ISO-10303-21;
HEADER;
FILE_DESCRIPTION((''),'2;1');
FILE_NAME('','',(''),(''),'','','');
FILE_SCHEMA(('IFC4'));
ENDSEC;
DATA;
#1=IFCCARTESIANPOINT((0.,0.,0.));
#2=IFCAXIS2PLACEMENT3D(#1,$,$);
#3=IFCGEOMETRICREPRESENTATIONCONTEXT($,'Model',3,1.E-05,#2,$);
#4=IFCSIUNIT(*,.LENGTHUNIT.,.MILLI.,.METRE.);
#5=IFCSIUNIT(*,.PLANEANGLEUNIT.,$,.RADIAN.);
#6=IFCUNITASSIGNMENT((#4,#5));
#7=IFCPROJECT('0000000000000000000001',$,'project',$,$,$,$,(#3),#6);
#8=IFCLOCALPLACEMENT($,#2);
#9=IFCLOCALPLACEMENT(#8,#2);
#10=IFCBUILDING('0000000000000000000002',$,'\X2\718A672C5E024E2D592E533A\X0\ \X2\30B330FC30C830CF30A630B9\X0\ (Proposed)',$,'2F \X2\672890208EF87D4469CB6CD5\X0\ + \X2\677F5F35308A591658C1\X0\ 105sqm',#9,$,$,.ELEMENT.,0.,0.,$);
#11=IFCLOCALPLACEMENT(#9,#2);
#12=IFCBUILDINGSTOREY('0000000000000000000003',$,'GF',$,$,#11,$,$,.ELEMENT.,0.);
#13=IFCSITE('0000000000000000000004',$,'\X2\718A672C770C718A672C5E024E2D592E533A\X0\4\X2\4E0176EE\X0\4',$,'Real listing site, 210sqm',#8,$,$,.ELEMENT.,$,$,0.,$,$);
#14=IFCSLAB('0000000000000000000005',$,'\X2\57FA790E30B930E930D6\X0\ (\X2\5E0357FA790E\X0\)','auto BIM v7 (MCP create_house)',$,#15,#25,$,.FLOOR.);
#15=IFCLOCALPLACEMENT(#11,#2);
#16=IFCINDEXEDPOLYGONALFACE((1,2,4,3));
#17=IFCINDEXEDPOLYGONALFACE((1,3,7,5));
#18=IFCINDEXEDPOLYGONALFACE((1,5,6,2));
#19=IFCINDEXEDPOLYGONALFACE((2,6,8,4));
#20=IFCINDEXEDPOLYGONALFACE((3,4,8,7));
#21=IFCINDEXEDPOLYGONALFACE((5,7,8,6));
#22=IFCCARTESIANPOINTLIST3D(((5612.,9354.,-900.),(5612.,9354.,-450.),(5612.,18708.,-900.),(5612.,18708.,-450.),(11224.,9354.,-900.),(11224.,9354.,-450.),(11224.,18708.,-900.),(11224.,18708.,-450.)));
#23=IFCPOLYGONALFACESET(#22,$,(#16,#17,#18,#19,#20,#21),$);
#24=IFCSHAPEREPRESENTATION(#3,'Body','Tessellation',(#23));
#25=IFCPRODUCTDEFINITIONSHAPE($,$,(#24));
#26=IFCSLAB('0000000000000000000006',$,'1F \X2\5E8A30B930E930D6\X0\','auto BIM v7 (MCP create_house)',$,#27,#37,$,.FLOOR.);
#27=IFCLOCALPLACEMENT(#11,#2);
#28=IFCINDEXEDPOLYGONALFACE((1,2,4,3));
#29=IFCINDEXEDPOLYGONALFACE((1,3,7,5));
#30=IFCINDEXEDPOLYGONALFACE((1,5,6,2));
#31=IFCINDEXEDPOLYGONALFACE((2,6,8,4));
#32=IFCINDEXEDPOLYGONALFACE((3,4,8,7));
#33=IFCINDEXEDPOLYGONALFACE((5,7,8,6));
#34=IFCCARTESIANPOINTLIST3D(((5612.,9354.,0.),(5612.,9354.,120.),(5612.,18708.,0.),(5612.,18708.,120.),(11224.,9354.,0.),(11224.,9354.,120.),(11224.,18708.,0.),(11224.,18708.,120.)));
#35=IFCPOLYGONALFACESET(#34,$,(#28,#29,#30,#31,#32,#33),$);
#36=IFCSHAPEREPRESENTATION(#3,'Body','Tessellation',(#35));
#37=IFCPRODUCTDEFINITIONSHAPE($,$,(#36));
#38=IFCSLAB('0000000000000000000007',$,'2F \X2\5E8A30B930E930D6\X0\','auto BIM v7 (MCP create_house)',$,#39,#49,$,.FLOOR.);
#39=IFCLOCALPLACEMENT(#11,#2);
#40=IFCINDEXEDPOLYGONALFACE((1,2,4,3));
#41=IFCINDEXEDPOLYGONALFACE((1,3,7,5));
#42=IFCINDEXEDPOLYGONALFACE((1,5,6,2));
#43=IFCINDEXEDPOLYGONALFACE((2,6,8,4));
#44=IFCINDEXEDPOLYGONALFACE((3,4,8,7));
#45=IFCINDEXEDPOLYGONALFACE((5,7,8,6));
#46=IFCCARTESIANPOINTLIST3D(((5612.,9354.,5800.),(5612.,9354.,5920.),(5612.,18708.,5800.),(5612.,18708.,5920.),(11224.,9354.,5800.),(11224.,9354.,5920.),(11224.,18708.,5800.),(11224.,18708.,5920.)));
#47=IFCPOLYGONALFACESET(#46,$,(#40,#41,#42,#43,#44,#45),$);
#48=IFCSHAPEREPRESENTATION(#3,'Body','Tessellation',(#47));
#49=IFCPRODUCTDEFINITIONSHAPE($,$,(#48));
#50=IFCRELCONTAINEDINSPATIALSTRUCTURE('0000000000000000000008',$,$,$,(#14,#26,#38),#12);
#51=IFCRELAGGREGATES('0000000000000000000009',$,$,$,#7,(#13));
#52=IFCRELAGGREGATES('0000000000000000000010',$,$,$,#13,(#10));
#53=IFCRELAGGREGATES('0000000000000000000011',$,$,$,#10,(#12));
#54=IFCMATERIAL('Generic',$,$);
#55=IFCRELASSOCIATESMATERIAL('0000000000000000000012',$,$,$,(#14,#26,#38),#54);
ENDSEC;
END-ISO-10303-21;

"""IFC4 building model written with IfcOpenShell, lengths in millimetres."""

from ifc_helpers import new_model, si_unit, frame, frame_2d, origin, place, context, project, spatial, rectangle, extrude, material, element, save


model = new_model("IFC4")

# Units and contexts
model_context = context("Model", 3, precision=1e-05, world=origin())
ifc_project = project(units=[si_unit("LENGTHUNIT", "METRE", prefix="MILLI"), si_unit("PLANEANGLEUNIT", "RADIAN")], contexts=[model_context])

# Site, building, storey
site_placement = place(None, origin())
site = spatial("IfcSite", under=ifc_project, at=site_placement, Name="熊本県熊本市中央区4丁目4", ObjectType="Real listing site, 210sqm", CompositionType="ELEMENT", RefElevation=0.0)
building_placement = place(site_placement, origin())
building = spatial("IfcBuilding", under=site, at=building_placement, Name="熊本市中央区 コートハウス (Proposed)", ObjectType="2F 木造軸組構法 + 板張り外壁 105sqm", CompositionType="ELEMENT", ElevationOfRefHeight=0.0, ElevationOfTerrain=0.0)
storey_placement = place(building_placement, origin())
storey = spatial("IfcBuildingStorey", under=building, at=storey_placement, Name="GF", CompositionType="ELEMENT", Elevation=0.0)

# Slabs
ifc_material = material(Name="Generic")
slab_1_placement = place(storey_placement, frame((2806.0, 4677.0, -450.0)))
element("IfcSlab", 1, at=slab_1_placement, inside=storey, material=ifc_material, Name="基礎スラブ (布基礎)", Description="auto BIM v7 (MCP create_house)", PredefinedType="FLOOR", context=model_context, shape_type="SweptSolid", body=[
    extrude(rectangle(XDim=5612.0, YDim=9354.0, at=frame_2d((2806.0, 4677.0))), frame((2806.0, 4677.0, -450.0)), (0.0, 0.0, 1.0), 450.0),
])
slab_2_placement = place(storey_placement, frame((2806.0, 4677.0, 0.0)))
element("IfcSlab", 2, at=slab_2_placement, inside=storey, material=ifc_material, Name="1F 床スラブ", Description="auto BIM v7 (MCP create_house)", PredefinedType="FLOOR", context=model_context, shape_type="SweptSolid", body=[
    extrude(rectangle(XDim=5612.0, YDim=9354.0, at=frame_2d((2806.0, 4677.0))), frame((2806.0, 4677.0, 0.0)), (0.0, 0.0, 1.0), 120.0),
])
slab_3_placement = place(storey_placement, frame((2806.0, 4677.0, 2900.0)))
element("IfcSlab", 3, at=slab_3_placement, inside=storey, material=ifc_material, Name="2F 床スラブ", Description="auto BIM v7 (MCP create_house)", PredefinedType="FLOOR", context=model_context, shape_type="SweptSolid", body=[
    extrude(rectangle(XDim=5612.0, YDim=9354.0, at=frame_2d((2806.0, 4677.0))), frame((2806.0, 4677.0, 2900.0)), (0.0, 0.0, 1.0), 120.0),
])

save(model, "model.ifc")
